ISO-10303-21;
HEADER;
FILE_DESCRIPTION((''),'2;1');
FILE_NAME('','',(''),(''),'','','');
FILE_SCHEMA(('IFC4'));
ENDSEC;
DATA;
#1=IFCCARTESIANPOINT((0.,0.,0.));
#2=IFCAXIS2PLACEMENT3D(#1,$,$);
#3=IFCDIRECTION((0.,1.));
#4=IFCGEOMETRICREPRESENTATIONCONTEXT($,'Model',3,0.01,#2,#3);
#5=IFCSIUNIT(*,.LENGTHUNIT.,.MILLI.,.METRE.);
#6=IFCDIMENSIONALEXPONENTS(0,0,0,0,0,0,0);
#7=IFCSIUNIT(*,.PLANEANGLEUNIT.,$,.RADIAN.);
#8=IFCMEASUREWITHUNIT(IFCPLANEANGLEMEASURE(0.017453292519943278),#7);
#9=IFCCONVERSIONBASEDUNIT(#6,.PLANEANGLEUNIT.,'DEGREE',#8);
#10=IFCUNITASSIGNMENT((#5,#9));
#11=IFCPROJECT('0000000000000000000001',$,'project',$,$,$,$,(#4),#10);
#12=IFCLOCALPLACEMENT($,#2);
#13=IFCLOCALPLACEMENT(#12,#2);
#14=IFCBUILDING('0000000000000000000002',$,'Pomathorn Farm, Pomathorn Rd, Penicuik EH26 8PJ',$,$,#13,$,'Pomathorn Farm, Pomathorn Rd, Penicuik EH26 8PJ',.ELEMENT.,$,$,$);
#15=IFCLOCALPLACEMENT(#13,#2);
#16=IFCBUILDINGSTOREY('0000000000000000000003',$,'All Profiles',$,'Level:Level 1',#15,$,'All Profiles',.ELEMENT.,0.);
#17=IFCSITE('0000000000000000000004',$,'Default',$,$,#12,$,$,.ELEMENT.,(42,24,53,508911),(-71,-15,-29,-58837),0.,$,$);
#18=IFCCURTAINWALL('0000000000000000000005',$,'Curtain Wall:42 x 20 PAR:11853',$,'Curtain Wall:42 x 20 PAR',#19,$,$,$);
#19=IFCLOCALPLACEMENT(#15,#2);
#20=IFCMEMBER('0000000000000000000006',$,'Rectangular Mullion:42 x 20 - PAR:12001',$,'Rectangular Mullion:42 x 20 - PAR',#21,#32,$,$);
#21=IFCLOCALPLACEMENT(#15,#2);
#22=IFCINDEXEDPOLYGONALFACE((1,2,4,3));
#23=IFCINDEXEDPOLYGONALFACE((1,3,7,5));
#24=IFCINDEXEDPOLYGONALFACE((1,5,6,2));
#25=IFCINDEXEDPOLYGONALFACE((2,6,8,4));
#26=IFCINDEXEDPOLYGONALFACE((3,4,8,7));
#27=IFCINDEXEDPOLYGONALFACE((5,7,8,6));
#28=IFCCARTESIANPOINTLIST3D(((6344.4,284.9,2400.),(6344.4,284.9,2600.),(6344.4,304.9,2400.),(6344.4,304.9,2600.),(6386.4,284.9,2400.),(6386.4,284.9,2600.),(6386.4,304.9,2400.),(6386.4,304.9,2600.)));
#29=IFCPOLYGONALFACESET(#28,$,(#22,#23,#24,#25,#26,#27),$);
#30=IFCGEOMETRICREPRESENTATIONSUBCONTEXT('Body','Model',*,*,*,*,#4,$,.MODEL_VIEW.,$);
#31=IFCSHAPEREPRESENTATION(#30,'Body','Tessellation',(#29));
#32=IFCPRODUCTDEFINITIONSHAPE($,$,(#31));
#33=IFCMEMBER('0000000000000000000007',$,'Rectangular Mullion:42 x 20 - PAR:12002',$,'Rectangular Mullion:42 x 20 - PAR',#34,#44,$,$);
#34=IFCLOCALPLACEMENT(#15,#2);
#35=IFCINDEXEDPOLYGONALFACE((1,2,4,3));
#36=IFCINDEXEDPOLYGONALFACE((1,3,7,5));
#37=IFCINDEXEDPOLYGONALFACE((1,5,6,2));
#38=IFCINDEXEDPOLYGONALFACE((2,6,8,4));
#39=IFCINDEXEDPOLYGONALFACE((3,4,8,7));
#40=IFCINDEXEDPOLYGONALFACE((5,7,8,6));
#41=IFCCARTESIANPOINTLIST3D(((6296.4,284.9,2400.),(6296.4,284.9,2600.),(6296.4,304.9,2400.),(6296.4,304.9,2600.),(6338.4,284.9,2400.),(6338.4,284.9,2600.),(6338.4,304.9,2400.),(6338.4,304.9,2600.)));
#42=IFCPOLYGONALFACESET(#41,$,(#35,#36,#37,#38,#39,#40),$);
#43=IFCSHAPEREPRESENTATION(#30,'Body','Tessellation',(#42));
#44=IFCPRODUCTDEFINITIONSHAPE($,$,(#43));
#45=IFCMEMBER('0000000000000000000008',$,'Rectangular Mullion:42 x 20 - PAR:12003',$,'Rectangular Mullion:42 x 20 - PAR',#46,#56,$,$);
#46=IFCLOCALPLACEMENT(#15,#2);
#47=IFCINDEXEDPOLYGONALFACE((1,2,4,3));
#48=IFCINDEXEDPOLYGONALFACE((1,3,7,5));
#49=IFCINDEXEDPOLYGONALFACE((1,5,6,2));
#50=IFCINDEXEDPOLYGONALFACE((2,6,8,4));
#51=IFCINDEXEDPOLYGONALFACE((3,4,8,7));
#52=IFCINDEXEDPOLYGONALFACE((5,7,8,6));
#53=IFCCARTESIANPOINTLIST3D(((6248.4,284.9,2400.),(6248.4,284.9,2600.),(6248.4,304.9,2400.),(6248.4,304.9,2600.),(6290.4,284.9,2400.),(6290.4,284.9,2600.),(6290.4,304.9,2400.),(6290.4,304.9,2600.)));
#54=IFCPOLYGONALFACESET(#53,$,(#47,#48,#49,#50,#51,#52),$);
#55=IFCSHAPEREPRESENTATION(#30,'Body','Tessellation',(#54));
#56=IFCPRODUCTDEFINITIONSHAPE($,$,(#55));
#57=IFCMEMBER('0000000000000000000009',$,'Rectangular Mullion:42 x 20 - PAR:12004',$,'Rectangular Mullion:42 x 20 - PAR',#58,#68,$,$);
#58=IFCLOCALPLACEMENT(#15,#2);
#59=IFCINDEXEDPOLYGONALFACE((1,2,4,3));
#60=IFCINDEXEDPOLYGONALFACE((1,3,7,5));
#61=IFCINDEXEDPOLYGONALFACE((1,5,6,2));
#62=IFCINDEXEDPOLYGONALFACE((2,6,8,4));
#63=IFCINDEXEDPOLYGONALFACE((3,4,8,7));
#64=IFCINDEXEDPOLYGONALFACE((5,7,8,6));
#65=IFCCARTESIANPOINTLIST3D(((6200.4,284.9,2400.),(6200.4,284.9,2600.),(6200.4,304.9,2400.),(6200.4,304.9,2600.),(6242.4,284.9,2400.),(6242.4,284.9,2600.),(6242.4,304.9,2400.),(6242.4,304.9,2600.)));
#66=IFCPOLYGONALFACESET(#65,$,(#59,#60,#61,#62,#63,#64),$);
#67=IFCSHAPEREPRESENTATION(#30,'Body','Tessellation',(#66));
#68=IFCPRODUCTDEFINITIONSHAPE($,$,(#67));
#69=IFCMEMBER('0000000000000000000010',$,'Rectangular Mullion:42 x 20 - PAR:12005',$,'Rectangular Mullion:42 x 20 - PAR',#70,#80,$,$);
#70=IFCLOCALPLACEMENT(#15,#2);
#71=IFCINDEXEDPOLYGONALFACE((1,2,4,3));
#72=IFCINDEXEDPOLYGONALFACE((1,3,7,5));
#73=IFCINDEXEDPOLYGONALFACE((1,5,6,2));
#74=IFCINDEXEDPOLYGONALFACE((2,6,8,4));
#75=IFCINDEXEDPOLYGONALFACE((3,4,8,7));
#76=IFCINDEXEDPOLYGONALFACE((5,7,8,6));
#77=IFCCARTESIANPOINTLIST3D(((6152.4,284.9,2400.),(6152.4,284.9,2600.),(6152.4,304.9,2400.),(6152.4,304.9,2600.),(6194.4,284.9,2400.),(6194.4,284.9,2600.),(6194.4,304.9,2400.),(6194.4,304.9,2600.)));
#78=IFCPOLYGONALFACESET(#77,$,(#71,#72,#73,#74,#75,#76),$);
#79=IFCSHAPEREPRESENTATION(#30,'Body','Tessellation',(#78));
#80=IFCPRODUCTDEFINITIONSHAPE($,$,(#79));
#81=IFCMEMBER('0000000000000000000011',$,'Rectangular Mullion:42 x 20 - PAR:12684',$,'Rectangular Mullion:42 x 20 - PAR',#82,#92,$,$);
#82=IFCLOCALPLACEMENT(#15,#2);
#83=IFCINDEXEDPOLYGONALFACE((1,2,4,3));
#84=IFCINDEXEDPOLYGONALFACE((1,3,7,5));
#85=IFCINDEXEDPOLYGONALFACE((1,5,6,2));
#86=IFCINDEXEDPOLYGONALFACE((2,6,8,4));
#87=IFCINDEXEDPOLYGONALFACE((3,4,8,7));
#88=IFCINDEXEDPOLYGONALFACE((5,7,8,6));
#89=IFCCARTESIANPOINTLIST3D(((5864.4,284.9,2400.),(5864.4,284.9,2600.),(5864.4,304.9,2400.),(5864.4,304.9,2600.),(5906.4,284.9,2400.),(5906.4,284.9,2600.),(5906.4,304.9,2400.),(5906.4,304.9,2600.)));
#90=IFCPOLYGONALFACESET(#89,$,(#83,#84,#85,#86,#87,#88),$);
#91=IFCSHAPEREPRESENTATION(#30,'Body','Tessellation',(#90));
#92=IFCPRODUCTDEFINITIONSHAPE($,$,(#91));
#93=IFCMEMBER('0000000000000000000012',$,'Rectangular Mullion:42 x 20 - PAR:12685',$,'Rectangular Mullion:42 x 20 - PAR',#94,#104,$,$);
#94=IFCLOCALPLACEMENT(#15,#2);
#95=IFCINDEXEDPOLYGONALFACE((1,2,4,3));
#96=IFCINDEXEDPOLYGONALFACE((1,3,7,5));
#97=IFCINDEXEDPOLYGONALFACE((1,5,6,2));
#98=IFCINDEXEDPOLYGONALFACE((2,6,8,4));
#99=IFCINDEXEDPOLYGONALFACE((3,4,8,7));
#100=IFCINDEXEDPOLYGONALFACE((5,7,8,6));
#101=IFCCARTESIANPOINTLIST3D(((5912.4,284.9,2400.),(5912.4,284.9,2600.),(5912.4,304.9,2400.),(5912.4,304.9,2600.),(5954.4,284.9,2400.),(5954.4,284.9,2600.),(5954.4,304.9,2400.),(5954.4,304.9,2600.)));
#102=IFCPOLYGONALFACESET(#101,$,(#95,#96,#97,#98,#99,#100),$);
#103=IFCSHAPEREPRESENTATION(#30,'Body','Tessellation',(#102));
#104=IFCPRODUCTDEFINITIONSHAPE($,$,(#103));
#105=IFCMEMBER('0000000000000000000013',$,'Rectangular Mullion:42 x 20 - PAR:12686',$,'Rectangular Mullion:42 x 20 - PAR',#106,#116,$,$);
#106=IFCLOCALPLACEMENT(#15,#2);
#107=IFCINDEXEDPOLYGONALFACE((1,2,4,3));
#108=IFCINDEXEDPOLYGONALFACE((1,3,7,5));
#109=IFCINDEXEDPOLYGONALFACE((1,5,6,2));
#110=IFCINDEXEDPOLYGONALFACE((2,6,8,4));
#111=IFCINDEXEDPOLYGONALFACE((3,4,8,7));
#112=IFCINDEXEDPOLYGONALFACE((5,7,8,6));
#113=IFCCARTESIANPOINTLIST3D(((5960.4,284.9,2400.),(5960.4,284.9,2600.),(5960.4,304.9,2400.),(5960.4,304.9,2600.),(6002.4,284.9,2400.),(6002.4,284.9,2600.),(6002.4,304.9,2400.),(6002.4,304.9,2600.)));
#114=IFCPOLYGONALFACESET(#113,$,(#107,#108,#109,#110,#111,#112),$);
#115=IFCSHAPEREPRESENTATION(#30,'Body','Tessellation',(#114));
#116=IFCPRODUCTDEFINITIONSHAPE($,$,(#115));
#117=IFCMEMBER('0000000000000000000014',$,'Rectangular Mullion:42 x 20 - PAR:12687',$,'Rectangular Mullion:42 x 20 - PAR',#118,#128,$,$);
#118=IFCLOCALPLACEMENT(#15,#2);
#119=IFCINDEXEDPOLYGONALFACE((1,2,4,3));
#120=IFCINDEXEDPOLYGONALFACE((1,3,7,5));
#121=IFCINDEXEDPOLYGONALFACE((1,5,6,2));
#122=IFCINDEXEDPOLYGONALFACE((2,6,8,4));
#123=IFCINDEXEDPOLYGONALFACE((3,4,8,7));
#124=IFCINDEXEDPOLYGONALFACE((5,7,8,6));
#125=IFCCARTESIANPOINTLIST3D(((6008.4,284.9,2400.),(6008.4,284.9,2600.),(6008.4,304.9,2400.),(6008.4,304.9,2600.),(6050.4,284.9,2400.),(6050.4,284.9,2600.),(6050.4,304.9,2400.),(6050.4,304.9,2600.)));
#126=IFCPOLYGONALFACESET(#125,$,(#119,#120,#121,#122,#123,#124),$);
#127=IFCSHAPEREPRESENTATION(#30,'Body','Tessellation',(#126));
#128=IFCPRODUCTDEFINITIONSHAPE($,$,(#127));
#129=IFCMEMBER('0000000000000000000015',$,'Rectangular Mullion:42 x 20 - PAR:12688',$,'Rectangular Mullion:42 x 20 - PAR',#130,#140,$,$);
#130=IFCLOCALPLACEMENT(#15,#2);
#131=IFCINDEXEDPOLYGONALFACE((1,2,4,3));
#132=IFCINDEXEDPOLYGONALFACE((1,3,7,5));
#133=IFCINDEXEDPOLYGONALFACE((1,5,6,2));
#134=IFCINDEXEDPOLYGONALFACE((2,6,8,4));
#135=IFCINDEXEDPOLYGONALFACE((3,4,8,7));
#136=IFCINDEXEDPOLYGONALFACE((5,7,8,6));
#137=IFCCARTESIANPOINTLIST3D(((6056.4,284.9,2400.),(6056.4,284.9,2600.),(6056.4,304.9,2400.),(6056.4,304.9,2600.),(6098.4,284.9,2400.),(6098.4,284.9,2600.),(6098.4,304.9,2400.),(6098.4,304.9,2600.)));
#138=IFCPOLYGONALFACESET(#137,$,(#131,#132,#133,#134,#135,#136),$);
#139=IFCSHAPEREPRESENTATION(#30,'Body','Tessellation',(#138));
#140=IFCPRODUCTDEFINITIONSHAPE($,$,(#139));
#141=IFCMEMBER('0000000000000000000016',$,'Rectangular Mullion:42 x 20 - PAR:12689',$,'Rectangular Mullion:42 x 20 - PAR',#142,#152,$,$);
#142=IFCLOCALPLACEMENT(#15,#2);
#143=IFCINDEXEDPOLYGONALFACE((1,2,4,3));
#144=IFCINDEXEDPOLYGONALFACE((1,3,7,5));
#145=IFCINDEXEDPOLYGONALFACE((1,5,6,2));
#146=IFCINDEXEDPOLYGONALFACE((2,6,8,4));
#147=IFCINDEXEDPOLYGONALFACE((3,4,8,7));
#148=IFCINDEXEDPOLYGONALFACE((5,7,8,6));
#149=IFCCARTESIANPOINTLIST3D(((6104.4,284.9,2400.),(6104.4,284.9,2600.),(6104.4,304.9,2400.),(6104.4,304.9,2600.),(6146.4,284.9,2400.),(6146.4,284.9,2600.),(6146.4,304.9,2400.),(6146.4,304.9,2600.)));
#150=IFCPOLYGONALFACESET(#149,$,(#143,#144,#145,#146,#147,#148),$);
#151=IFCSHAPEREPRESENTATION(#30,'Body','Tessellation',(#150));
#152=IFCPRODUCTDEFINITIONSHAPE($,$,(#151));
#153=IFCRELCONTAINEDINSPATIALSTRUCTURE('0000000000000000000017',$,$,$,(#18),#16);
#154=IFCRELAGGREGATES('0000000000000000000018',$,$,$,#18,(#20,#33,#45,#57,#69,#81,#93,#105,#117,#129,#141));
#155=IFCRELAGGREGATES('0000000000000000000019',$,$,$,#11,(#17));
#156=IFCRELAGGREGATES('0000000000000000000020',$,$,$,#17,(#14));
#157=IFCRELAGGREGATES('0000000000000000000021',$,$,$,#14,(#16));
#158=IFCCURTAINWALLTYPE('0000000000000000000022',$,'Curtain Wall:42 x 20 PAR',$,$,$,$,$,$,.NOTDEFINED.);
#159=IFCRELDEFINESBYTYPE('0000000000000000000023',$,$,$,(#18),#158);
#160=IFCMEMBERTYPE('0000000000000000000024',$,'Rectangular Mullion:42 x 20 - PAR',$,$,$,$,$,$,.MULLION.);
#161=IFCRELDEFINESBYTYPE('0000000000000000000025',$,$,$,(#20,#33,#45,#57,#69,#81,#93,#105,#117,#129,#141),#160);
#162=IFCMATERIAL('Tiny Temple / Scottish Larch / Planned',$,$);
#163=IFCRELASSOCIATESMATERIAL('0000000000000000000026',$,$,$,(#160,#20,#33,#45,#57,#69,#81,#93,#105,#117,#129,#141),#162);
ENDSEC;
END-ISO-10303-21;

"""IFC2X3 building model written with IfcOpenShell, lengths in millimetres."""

from ifc_helpers import new_model, entity, si_unit, converted_unit, direction, frame, frame_2d, origin, place, context, subcontext, project, spatial, rectangle, extrude, source, transform, mapped, material, type_object, type_shapes, element, aggregate, save


model = new_model("IFC2X3")

# Units and contexts
model_context = context("Model", 3, precision=0.01, world=origin(), true_north=direction((0.0, 1.0)))
body_context = subcontext(model_context, "Body", "Model", "MODEL_VIEW")
ifc_project = project(units=[si_unit("LENGTHUNIT", "METRE", prefix="MILLI"), converted_unit("PLANEANGLEUNIT", "DEGREE", entity("IfcPlaneAngleMeasure", 0.017453292519943278), si_unit("PLANEANGLEUNIT", "RADIAN"), dimensions=[0, 0, 0, 0, 0, 0, 0])], contexts=[model_context])

# Site, building, storey
site_placement = place(None, origin())
site = spatial("IfcSite", under=ifc_project, at=site_placement, Name="Default", CompositionType="ELEMENT", RefLatitude=(42, 24, 53, 508911), RefLongitude=(-71, -15, -29, -58837), RefElevation=0.0)
building_placement = place(site_placement, origin())
building = spatial("IfcBuilding", under=site, at=building_placement, Name="Pomathorn Farm, Pomathorn Rd, Penicuik EH26 8PJ", LongName="Pomathorn Farm, Pomathorn Rd, Penicuik EH26 8PJ", CompositionType="ELEMENT")
storey_placement = place(building_placement, origin())
storey = spatial("IfcBuildingStorey", under=building, at=storey_placement, Name="All Profiles", ObjectType="Level:Level 1", LongName="All Profiles", CompositionType="ELEMENT", Elevation=0.0)

# Curtain wall, members
curtain_wall_type = type_object("IfcCurtainWallType", Name="Curtain Wall:42 x 20 PAR", PredefinedType="NOTDEFINED")
curtain_wall_placement = place(storey_placement, origin())
curtain_wall = element("IfcCurtainWall", 1, at=curtain_wall_placement, inside=storey, type_object=curtain_wall_type, Name="Curtain Wall:42 x 20 PAR:11853", ObjectType="Curtain Wall:42 x 20 PAR")
ifc_material = material(Name="Tiny Temple / Scottish Larch / Planned")
member_type = type_object("IfcMemberType", Name="Rectangular Mullion:42 x 20 - PAR", PredefinedType="MULLION", material=ifc_material)
shared_shape = source(origin(), body_context, "Body", "SweptSolid", [
    extrude(rectangle(XDim=20.0, YDim=42.0, at=frame_2d((0.0, 0.0), x_axis=(1.0, 0.0))), frame((-21.0, -10.0, -200.0), z_axis=(0.0, 0.0, 1.0), x_axis=(0.0, 1.0, 0.0)), (0.0, 0.0, 1.0), 200.0),
])
type_shapes(member_type, [shared_shape])
member_1_placement = place(curtain_wall_placement, frame((6386.4, 284.9, 2400.0), z_axis=(0.0, 0.0, -1.0), x_axis=(1.0, 0.0, 0.0)))
member_1 = element("IfcMember", 2, at=member_1_placement, type_object=member_type, material=ifc_material, Name="Rectangular Mullion:42 x 20 - PAR:12001", ObjectType="Rectangular Mullion:42 x 20 - PAR", context=body_context, shape_type="MappedRepresentation", body=[
    mapped(shared_shape, transform((0.0, 0.0, 0.0), scale=1.0)),
])
member_2_placement = place(curtain_wall_placement, frame((6338.4, 284.9, 2400.0), z_axis=(0.0, 0.0, -1.0), x_axis=(1.0, 0.0, 0.0)))
member_2 = element("IfcMember", 3, at=member_2_placement, type_object=member_type, material=ifc_material, Name="Rectangular Mullion:42 x 20 - PAR:12002", ObjectType="Rectangular Mullion:42 x 20 - PAR", context=body_context, shape_type="MappedRepresentation", body=[
    mapped(shared_shape, transform((0.0, 0.0, 0.0), scale=1.0)),
])
member_3_placement = place(curtain_wall_placement, frame((6290.4, 284.9, 2400.0), z_axis=(0.0, 0.0, -1.0), x_axis=(1.0, 0.0, 0.0)))
member_3 = element("IfcMember", 4, at=member_3_placement, type_object=member_type, material=ifc_material, Name="Rectangular Mullion:42 x 20 - PAR:12003", ObjectType="Rectangular Mullion:42 x 20 - PAR", context=body_context, shape_type="MappedRepresentation", body=[
    mapped(shared_shape, transform((0.0, 0.0, 0.0), scale=1.0)),
])
member_4_placement = place(curtain_wall_placement, frame((6242.4, 284.9, 2400.0), z_axis=(0.0, 0.0, -1.0), x_axis=(1.0, 0.0, 0.0)))
member_4 = element("IfcMember", 5, at=member_4_placement, type_object=member_type, material=ifc_material, Name="Rectangular Mullion:42 x 20 - PAR:12004", ObjectType="Rectangular Mullion:42 x 20 - PAR", context=body_context, shape_type="MappedRepresentation", body=[
    mapped(shared_shape, transform((0.0, 0.0, 0.0), scale=1.0)),
])
member_5_placement = place(curtain_wall_placement, frame((6194.4, 284.9, 2400.0), z_axis=(0.0, 0.0, -1.0), x_axis=(1.0, 0.0, 0.0)))
member_5 = element("IfcMember", 6, at=member_5_placement, type_object=member_type, material=ifc_material, Name="Rectangular Mullion:42 x 20 - PAR:12005", ObjectType="Rectangular Mullion:42 x 20 - PAR", context=body_context, shape_type="MappedRepresentation", body=[
    mapped(shared_shape, transform((0.0, 0.0, 0.0), scale=1.0)),
])
member_6_placement = place(curtain_wall_placement, frame((5906.4, 284.9, 2400.0), z_axis=(0.0, 0.0, -1.0), x_axis=(1.0, 0.0, 0.0)))
member_6 = element("IfcMember", 7, at=member_6_placement, type_object=member_type, material=ifc_material, Name="Rectangular Mullion:42 x 20 - PAR:12684", ObjectType="Rectangular Mullion:42 x 20 - PAR", context=body_context, shape_type="MappedRepresentation", body=[
    mapped(shared_shape, transform((0.0, 0.0, 0.0), scale=1.0)),
])
member_7_placement = place(curtain_wall_placement, frame((5954.4, 284.9, 2400.0), z_axis=(0.0, 0.0, -1.0), x_axis=(1.0, 0.0, 0.0)))
member_7 = element("IfcMember", 8, at=member_7_placement, type_object=member_type, material=ifc_material, Name="Rectangular Mullion:42 x 20 - PAR:12685", ObjectType="Rectangular Mullion:42 x 20 - PAR", context=body_context, shape_type="MappedRepresentation", body=[
    mapped(shared_shape, transform((0.0, 0.0, 0.0), scale=1.0)),
])
member_8_placement = place(curtain_wall_placement, frame((6002.4, 284.9, 2400.0), z_axis=(0.0, 0.0, -1.0), x_axis=(1.0, 0.0, 0.0)))
member_8 = element("IfcMember", 9, at=member_8_placement, type_object=member_type, material=ifc_material, Name="Rectangular Mullion:42 x 20 - PAR:12686", ObjectType="Rectangular Mullion:42 x 20 - PAR", context=body_context, shape_type="MappedRepresentation", body=[
    mapped(shared_shape, transform((0.0, 0.0, 0.0), scale=1.0)),
])
member_9_placement = place(curtain_wall_placement, frame((6050.4, 284.9, 2400.0), z_axis=(0.0, 0.0, -1.0), x_axis=(1.0, 0.0, 0.0)))
member_9 = element("IfcMember", 10, at=member_9_placement, type_object=member_type, material=ifc_material, Name="Rectangular Mullion:42 x 20 - PAR:12687", ObjectType="Rectangular Mullion:42 x 20 - PAR", context=body_context, shape_type="MappedRepresentation", body=[
    mapped(shared_shape, transform((0.0, 0.0, 0.0), scale=1.0)),
])
member_10_placement = place(curtain_wall_placement, frame((6098.4, 284.9, 2400.0), z_axis=(0.0, 0.0, -1.0), x_axis=(1.0, 0.0, 0.0)))
member_10 = element("IfcMember", 11, at=member_10_placement, type_object=member_type, material=ifc_material, Name="Rectangular Mullion:42 x 20 - PAR:12688", ObjectType="Rectangular Mullion:42 x 20 - PAR", context=body_context, shape_type="MappedRepresentation", body=[
    mapped(shared_shape, transform((0.0, 0.0, 0.0), scale=1.0)),
])
member_11_placement = place(curtain_wall_placement, frame((6146.4, 284.9, 2400.0), z_axis=(0.0, 0.0, -1.0), x_axis=(1.0, 0.0, 0.0)))
member_11 = element("IfcMember", 12, at=member_11_placement, type_object=member_type, material=ifc_material, Name="Rectangular Mullion:42 x 20 - PAR:12689", ObjectType="Rectangular Mullion:42 x 20 - PAR", context=body_context, shape_type="MappedRepresentation", body=[
    mapped(shared_shape, transform((0.0, 0.0, 0.0), scale=1.0)),
])
aggregate(curtain_wall, [member_1, member_2, member_3, member_4, member_5, member_6, member_7, member_8, member_9, member_10, member_11])

save(model, "model.ifc")
